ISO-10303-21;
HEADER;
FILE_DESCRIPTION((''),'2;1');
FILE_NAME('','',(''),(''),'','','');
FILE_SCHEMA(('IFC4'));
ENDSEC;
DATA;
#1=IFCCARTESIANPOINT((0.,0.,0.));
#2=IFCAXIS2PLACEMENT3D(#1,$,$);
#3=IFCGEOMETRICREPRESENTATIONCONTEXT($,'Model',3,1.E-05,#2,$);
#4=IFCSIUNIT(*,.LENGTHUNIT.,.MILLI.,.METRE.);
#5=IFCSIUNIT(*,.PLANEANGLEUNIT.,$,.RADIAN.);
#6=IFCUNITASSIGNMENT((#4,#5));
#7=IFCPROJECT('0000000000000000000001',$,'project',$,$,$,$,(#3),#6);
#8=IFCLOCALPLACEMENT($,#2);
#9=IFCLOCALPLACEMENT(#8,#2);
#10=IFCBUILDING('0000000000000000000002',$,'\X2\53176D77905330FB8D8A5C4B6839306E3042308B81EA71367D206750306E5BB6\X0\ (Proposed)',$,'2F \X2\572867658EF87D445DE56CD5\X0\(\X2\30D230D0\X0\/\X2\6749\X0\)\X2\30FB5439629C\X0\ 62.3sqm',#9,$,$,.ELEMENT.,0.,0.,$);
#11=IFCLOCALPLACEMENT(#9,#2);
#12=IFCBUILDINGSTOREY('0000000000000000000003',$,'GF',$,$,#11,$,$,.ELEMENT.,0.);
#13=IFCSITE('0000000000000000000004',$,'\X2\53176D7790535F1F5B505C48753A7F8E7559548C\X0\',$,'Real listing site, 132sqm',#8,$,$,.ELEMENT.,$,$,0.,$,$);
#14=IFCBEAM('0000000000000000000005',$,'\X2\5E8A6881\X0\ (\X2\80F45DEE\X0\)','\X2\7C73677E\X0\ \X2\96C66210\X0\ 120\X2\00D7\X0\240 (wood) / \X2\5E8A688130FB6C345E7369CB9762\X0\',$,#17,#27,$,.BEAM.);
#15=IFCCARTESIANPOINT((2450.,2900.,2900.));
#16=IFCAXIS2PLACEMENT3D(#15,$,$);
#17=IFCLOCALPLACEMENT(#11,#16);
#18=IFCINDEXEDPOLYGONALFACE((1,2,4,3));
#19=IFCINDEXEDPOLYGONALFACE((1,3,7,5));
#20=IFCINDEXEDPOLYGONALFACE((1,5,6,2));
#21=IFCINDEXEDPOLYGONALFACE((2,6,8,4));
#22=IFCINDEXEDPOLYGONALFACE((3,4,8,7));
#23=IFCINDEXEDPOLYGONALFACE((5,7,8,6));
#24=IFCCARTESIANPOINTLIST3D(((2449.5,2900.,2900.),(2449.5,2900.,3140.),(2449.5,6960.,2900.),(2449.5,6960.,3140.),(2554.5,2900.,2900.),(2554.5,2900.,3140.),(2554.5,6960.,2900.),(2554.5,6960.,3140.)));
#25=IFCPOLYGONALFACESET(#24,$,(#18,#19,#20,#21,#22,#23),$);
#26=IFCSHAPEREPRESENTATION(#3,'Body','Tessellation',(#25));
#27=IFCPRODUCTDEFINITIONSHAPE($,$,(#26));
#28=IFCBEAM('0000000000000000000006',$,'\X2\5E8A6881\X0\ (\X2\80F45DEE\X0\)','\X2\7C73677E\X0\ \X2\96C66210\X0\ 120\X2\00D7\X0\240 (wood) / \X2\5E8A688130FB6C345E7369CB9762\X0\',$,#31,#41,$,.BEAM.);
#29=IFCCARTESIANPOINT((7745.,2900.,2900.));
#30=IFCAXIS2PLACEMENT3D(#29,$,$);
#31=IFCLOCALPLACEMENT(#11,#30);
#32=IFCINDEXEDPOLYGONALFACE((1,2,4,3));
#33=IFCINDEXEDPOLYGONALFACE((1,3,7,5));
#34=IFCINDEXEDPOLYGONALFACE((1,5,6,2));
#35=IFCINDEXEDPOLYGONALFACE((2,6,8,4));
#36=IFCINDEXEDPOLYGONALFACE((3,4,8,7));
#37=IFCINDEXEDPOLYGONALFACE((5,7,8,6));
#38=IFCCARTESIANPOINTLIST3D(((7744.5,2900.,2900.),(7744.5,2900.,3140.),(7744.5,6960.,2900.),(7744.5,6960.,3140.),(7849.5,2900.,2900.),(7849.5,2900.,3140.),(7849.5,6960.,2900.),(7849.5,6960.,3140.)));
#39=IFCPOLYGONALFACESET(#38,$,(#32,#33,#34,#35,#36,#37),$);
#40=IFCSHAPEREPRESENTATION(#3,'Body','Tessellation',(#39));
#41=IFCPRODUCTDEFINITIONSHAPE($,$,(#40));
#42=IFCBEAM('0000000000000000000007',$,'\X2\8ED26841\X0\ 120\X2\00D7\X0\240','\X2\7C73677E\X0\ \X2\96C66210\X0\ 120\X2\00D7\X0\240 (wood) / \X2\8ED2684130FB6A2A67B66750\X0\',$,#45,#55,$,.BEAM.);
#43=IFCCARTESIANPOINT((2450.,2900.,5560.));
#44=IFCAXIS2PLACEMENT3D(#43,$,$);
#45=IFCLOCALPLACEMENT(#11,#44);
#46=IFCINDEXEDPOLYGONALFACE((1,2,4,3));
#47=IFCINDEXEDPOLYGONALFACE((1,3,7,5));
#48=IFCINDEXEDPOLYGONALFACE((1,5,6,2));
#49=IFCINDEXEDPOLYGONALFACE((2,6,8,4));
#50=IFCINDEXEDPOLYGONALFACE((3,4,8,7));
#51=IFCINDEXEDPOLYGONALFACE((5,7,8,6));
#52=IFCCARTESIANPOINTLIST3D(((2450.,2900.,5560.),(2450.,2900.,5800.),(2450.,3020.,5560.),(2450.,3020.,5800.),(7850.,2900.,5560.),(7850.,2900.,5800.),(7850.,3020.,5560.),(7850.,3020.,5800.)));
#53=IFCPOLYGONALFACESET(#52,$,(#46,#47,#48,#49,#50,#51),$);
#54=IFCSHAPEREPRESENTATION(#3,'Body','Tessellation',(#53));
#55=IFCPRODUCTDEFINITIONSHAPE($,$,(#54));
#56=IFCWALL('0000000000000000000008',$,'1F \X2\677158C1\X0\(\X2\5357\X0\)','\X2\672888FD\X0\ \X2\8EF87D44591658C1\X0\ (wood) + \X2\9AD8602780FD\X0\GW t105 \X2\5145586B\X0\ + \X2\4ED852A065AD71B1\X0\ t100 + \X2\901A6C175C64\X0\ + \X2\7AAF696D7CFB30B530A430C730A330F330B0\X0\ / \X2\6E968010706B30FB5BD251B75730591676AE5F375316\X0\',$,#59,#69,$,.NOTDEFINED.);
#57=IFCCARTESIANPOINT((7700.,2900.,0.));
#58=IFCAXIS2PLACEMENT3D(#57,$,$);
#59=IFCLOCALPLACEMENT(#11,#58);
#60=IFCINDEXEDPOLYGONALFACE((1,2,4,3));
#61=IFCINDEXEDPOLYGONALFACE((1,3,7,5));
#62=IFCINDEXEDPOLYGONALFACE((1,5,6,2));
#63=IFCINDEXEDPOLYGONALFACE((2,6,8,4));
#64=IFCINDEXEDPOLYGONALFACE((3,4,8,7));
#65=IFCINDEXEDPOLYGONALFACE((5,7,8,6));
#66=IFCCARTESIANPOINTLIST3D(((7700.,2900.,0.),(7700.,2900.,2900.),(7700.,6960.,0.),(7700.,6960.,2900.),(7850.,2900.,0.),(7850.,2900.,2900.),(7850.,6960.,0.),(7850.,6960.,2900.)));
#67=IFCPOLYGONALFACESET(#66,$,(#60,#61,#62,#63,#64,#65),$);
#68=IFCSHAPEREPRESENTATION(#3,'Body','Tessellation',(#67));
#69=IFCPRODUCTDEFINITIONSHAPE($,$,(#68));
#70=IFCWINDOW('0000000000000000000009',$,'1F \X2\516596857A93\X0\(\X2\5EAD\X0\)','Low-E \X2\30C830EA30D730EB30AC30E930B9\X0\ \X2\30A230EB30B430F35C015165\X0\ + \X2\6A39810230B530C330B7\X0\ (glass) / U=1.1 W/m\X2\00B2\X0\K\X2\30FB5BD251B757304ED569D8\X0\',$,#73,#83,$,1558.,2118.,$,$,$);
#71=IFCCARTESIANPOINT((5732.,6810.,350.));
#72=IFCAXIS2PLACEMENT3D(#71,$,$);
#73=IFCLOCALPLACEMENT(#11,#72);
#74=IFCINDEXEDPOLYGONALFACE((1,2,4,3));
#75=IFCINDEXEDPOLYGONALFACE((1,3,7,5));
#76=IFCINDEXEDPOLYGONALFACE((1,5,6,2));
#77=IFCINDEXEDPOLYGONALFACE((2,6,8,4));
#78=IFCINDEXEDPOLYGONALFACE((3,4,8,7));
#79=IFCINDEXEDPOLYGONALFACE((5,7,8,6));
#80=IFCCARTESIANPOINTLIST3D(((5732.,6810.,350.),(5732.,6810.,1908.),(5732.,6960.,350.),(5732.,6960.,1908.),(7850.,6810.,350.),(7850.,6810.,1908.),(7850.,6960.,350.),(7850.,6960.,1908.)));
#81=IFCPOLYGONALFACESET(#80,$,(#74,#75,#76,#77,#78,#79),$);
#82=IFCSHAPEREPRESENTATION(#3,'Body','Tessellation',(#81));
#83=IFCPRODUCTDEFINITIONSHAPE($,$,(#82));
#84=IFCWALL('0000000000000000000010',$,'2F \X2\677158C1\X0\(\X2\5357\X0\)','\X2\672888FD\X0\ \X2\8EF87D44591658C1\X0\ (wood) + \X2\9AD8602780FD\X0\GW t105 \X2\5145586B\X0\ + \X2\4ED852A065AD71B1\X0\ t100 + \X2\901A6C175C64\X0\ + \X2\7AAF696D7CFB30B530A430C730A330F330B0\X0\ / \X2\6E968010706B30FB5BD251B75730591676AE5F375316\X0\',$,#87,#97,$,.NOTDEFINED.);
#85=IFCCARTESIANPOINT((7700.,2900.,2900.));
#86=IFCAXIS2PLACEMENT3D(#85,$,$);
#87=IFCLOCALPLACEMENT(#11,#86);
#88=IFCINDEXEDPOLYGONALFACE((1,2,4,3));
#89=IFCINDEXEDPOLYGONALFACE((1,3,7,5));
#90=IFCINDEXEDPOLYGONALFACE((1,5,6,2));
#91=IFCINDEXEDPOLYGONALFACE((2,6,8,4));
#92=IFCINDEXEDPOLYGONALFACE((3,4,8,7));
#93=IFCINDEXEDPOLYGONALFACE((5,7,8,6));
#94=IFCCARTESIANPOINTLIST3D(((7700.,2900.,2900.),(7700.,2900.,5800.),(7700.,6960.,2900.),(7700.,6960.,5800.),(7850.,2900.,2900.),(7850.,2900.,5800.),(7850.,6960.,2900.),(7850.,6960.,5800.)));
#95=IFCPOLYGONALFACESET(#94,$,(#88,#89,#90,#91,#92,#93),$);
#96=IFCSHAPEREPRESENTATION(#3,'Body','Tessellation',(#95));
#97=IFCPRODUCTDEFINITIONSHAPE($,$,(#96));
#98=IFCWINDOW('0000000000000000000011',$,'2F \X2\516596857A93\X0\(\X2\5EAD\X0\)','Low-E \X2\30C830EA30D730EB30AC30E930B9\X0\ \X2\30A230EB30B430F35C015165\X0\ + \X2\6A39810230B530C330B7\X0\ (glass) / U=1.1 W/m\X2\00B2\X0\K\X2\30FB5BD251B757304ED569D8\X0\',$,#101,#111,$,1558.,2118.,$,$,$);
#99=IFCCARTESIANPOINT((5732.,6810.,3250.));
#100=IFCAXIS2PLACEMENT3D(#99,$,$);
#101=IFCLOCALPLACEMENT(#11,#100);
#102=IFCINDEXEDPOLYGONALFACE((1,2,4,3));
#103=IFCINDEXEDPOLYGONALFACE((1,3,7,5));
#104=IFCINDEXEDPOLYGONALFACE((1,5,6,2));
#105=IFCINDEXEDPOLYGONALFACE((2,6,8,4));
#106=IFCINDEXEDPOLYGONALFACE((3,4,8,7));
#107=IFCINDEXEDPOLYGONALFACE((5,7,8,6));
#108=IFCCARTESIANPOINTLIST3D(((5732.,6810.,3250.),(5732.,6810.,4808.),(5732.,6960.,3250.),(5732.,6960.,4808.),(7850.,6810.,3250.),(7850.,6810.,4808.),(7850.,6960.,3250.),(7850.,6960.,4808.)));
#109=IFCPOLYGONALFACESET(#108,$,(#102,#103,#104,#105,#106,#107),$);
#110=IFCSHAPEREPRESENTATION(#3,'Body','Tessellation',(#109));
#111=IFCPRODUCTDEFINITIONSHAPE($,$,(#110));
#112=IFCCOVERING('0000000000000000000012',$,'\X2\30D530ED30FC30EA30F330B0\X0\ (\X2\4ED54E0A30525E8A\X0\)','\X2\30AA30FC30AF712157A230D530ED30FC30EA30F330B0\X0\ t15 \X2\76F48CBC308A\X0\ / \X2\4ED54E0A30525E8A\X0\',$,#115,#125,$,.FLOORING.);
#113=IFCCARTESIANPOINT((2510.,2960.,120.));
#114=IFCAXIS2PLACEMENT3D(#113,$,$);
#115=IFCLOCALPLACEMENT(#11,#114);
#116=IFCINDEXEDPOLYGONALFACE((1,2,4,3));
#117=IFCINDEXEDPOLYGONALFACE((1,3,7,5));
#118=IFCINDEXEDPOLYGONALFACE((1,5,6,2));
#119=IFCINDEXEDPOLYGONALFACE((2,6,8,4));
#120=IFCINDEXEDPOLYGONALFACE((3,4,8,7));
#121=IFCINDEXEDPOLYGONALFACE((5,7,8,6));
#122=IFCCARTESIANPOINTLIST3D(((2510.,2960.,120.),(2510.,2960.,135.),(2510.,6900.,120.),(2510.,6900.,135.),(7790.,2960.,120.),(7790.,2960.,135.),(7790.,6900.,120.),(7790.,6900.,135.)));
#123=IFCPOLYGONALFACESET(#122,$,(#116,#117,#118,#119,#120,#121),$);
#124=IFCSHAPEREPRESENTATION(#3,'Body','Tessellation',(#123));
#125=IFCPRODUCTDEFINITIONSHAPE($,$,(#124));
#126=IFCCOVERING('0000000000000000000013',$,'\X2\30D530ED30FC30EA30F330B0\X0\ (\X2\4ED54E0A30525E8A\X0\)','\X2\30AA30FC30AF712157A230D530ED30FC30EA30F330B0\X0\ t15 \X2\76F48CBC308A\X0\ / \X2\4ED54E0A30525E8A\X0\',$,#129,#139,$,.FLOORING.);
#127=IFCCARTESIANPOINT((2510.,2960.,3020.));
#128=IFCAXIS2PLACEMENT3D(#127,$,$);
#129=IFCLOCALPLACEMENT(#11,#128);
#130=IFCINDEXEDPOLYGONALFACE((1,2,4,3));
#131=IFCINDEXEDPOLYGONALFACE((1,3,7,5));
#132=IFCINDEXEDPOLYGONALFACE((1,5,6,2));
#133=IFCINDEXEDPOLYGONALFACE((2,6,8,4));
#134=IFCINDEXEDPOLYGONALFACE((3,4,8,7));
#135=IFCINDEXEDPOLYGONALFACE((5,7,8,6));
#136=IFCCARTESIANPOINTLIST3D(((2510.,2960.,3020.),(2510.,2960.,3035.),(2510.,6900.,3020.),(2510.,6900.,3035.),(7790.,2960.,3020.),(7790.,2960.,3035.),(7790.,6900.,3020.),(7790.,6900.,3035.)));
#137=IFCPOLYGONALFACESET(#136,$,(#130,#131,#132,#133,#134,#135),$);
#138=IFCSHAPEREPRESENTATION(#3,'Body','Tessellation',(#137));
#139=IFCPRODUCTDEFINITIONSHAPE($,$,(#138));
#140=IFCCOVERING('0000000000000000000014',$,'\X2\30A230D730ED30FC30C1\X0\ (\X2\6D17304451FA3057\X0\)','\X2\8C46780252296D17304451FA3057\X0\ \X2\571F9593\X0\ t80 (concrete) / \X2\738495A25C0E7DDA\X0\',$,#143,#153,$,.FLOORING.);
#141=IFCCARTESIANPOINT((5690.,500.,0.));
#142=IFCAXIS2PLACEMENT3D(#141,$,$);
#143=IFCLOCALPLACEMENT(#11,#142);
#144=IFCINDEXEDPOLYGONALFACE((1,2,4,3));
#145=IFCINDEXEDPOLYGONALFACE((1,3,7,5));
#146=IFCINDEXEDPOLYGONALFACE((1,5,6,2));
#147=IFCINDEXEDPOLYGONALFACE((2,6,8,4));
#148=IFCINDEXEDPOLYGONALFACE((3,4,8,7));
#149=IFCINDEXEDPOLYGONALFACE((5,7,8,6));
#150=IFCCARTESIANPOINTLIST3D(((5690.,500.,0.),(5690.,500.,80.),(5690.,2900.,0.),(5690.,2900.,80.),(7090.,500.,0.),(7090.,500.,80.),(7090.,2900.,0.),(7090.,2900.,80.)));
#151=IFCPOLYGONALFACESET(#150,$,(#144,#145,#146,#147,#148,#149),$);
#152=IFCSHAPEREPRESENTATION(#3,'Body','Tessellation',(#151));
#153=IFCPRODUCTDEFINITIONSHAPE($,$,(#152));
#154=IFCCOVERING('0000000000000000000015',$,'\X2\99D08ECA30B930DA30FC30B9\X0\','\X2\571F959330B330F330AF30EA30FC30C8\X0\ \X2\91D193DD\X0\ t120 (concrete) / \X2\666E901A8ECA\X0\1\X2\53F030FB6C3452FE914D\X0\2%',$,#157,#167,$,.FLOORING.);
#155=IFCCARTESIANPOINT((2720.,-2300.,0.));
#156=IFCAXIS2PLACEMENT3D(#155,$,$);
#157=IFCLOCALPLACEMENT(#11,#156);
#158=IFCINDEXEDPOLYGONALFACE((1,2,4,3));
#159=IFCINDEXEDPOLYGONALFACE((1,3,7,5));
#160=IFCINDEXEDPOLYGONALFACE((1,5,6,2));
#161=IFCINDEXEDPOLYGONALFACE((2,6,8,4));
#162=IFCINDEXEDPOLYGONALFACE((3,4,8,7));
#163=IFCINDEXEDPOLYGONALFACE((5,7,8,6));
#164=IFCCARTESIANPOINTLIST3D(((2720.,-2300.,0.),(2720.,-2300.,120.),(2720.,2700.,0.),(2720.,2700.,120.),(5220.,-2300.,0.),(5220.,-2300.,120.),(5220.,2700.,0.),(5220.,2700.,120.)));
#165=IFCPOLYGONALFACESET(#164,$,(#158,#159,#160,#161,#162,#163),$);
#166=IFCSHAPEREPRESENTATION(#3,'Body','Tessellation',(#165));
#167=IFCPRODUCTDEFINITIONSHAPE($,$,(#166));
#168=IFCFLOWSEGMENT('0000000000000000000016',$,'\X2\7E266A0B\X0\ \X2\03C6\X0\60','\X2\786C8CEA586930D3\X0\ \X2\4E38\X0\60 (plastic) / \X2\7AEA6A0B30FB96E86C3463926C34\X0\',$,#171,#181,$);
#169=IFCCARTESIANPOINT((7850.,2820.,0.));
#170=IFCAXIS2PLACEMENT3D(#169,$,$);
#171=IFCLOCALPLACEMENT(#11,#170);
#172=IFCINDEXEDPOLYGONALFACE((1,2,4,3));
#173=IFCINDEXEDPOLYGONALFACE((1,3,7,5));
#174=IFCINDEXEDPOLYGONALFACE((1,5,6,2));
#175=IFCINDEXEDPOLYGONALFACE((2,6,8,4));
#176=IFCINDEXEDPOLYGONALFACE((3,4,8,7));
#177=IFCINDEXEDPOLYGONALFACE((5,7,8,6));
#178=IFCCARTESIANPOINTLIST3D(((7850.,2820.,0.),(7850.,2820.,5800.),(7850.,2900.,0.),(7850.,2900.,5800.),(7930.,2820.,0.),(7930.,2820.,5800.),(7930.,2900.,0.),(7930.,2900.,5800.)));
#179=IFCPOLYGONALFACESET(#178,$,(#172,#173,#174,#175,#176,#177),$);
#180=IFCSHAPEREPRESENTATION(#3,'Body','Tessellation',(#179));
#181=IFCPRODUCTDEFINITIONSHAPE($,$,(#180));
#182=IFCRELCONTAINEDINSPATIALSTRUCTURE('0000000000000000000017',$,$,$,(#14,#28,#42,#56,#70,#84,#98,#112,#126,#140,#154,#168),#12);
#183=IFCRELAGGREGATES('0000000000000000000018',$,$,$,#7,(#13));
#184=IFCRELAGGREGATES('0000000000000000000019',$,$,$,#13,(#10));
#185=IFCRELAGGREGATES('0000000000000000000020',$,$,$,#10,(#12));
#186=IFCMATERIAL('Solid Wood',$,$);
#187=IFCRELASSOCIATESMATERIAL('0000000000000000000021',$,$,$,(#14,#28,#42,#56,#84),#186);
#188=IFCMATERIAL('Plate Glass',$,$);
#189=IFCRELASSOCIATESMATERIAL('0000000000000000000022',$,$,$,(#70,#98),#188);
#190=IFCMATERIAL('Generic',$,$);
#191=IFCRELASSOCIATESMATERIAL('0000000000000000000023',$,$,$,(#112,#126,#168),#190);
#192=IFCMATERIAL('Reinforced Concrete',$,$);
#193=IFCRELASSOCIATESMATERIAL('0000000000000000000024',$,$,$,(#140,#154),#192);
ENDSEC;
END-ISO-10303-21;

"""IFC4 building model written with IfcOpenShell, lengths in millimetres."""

from ifc_helpers import new_model, si_unit, frame, frame_2d, origin, place, context, project, spatial, rectangle, extrude, material, element, fill, save


model = new_model("IFC4")

# Units and contexts
model_context = context("Model", 3, precision=1e-05, world=origin())
ifc_project = project(units=[si_unit("LENGTHUNIT", "METRE", prefix="MILLI"), si_unit("PLANEANGLEUNIT", "RADIAN")], contexts=[model_context])

# Site, building, storey
site_placement = place(None, origin())
site = spatial("IfcSite", under=ifc_project, at=site_placement, Name="北海道弟子屈町美留和", ObjectType="Real listing site, 132sqm", CompositionType="ELEMENT", RefElevation=0.0)
building_placement = place(site_placement, origin())
building = spatial("IfcBuilding", under=site, at=building_placement, Name="北海道・越屋根のある自然素材の家 (Proposed)", ObjectType="2F 在来軸組工法(ヒバ/杉)・吹抜 62.3sqm", CompositionType="ELEMENT", ElevationOfRefHeight=0.0, ElevationOfTerrain=0.0)
storey_placement = place(building_placement, origin())
storey = spatial("IfcBuildingStorey", under=building, at=storey_placement, Name="GF", CompositionType="ELEMENT", Elevation=0.0)

# Shared definitions
ifc_material_1 = material(Name="Solid Wood")

# Beams
beam_1_placement = place(storey_placement, frame((2450.0, 2900.0, 2900.0)))
element("IfcBeam", 1, at=beam_1_placement, inside=storey, material=ifc_material_1, Name="床梁 (胴差)", Description="米松 集成 120×240 (wood) / 床梁・水平構面", PredefinedType="BEAM", context=model_context, shape_type="SweptSolid", body=[
    extrude(rectangle(XDim=105.0, YDim=4060.0, at=frame_2d((52.0, 2030.0))), frame((2450.0, 2900.0, 2900.0)), (0.0, 0.0, 1.0), 240.0),
])
beam_2_placement = place(storey_placement, frame((7745.0, 2900.0, 2900.0)))
element("IfcBeam", 2, at=beam_2_placement, inside=storey, material=ifc_material_1, Name="床梁 (胴差)", Description="米松 集成 120×240 (wood) / 床梁・水平構面", PredefinedType="BEAM", context=model_context, shape_type="SweptSolid", body=[
    extrude(rectangle(XDim=105.0, YDim=4060.0, at=frame_2d((52.0, 2030.0))), frame((7745.0, 2900.0, 2900.0)), (0.0, 0.0, 1.0), 240.0),
])
beam_3_placement = place(storey_placement, frame((2450.0, 2900.0, 5560.0)))
element("IfcBeam", 3, at=beam_3_placement, inside=storey, material=ifc_material_1, Name="軒桁 120×240", Description="米松 集成 120×240 (wood) / 軒桁・横架材", PredefinedType="BEAM", context=model_context, shape_type="SweptSolid", body=[
    extrude(rectangle(XDim=5400.0, YDim=120.0, at=frame_2d((2700.0, 60.0))), frame((2450.0, 2900.0, 5560.0)), (0.0, 0.0, 1.0), 240.0),
])

# Wall, opening, window
wall_1_placement = place(storey_placement, frame((7700.0, 2900.0, 0.0)))
wall_1 = element("IfcWall", 4, at=wall_1_placement, inside=storey, material=ifc_material_1, Name="1F 東壁(南)", Description="木製 軸組外壁 (wood) + 高性能GW t105 充填 + 付加断熱 t100 + 通気層 + 窯業系サイディング / 準耐火・寒冷地外皮強化", PredefinedType="NOTDEFINED", context=model_context, shape_type="SweptSolid", body=[
    extrude(rectangle(XDim=150.0, YDim=4060.0, at=frame_2d((75.0, 2030.0))), frame((7700.0, 2900.0, 0.0)), (0.0, 0.0, 1.0), 2900.0),
])
opening_1_placement = place(storey_placement, frame((5732.0, 6810.0, 350.0)))
opening_1 = element("IfcOpeningElement", 5, at=opening_1_placement, cuts=wall_1, PredefinedType="NOTDEFINED", context=model_context, shape_type="SweptSolid", body=[
    extrude(rectangle(XDim=2118.0, YDim=150.0, at=frame_2d((1059.0, 75.0))), frame((5732.0, 6810.0, 350.0)), (0.0, 0.0, 1.0), 1558.0),
])
ifc_material_2 = material(Name="Plate Glass")
window_1_placement = place(storey_placement, frame((5732.0, 6810.0, 350.0)))
window_1 = element("IfcWindow", 6, at=window_1_placement, inside=storey, material=ifc_material_2, Name="1F 入隅窓(庭)", Description="Low-E トリプルガラス アルゴン封入 + 樹脂サッシ (glass) / U=1.1 W/m²K・寒冷地仕様", OverallHeight=1558.0, OverallWidth=2118.0, context=model_context, shape_type="SweptSolid", body=[
    extrude(rectangle(XDim=2118.0, YDim=150.0, at=frame_2d((1059.0, 75.0))), frame((5732.0, 6810.0, 350.0)), (0.0, 0.0, 1.0), 1558.0),
])
fill(opening_1, window_1)

# Wall, opening, window
wall_2_placement = place(storey_placement, frame((7700.0, 2900.0, 2900.0)))
wall_2 = element("IfcWall", 7, at=wall_2_placement, inside=storey, material=ifc_material_1, Name="2F 東壁(南)", Description="木製 軸組外壁 (wood) + 高性能GW t105 充填 + 付加断熱 t100 + 通気層 + 窯業系サイディング / 準耐火・寒冷地外皮強化", PredefinedType="NOTDEFINED", context=model_context, shape_type="SweptSolid", body=[
    extrude(rectangle(XDim=150.0, YDim=4060.0, at=frame_2d((75.0, 2030.0))), frame((7700.0, 2900.0, 2900.0)), (0.0, 0.0, 1.0), 2900.0),
])
opening_2_placement = place(storey_placement, frame((5732.0, 6810.0, 3250.0)))
opening_2 = element("IfcOpeningElement", 8, at=opening_2_placement, cuts=wall_2, PredefinedType="NOTDEFINED", context=model_context, shape_type="SweptSolid", body=[
    extrude(rectangle(XDim=2118.0, YDim=150.0, at=frame_2d((1059.0, 75.0))), frame((5732.0, 6810.0, 3250.0)), (0.0, 0.0, 1.0), 1558.0),
])
window_2_placement = place(storey_placement, frame((5732.0, 6810.0, 3250.0)))
window_2 = element("IfcWindow", 9, at=window_2_placement, inside=storey, material=ifc_material_2, Name="2F 入隅窓(庭)", Description="Low-E トリプルガラス アルゴン封入 + 樹脂サッシ (glass) / U=1.1 W/m²K・寒冷地仕様", OverallHeight=1558.0, OverallWidth=2118.0, context=model_context, shape_type="SweptSolid", body=[
    extrude(rectangle(XDim=2118.0, YDim=150.0, at=frame_2d((1059.0, 75.0))), frame((5732.0, 6810.0, 3250.0)), (0.0, 0.0, 1.0), 1558.0),
])
fill(opening_2, window_2)

# Coverings
ifc_material_3 = material(Name="Generic")
covering_1_placement = place(storey_placement, frame((2510.0, 2960.0, 120.0)))
element("IfcCovering", 10, at=covering_1_placement, inside=storey, material=ifc_material_3, Name="フローリング (仕上げ床)", Description="オーク無垢フローリング t15 直貼り / 仕上げ床", PredefinedType="FLOORING", context=model_context, shape_type="SweptSolid", body=[
    extrude(rectangle(XDim=5280.0, YDim=3940.0, at=frame_2d((2640.0, 1970.0))), frame((2510.0, 2960.0, 120.0)), (0.0, 0.0, 1.0), 15.0),
])
covering_2_placement = place(storey_placement, frame((2510.0, 2960.0, 3020.0)))
element("IfcCovering", 11, at=covering_2_placement, inside=storey, material=ifc_material_3, Name="フローリング (仕上げ床)", Description="オーク無垢フローリング t15 直貼り / 仕上げ床", PredefinedType="FLOORING", context=model_context, shape_type="SweptSolid", body=[
    extrude(rectangle(XDim=5280.0, YDim=3940.0, at=frame_2d((2640.0, 1970.0))), frame((2510.0, 2960.0, 3020.0)), (0.0, 0.0, 1.0), 15.0),
])
ifc_material_4 = material(Name="Reinforced Concrete")
covering_3_placement = place(storey_placement, frame((5690.0, 500.0, 0.0)))
element("IfcCovering", 12, at=covering_3_placement, inside=storey, material=ifc_material_4, Name="アプローチ (洗い出し)", Description="豆砂利洗い出し 土間 t80 (concrete) / 玄関導線", PredefinedType="FLOORING", context=model_context, shape_type="SweptSolid", body=[
    extrude(rectangle(XDim=1400.0, YDim=2400.0, at=frame_2d((700.0, 1200.0))), frame((5690.0, 500.0, 0.0)), (0.0, 0.0, 1.0), 80.0),
])
covering_4_placement = place(storey_placement, frame((2720.0, -2300.0, 0.0)))
element("IfcCovering", 13, at=covering_4_placement, inside=storey, material=ifc_material_4, Name="駐車スペース", Description="土間コンクリート 金鏝 t120 (concrete) / 普通車1台・水勾配2%", PredefinedType="FLOORING", context=model_context, shape_type="SweptSolid", body=[
    extrude(rectangle(XDim=2500.0, YDim=5000.0, at=frame_2d((1250.0, 2500.0))), frame((2720.0, -2300.0, 0.0)), (0.0, 0.0, 1.0), 120.0),
])

# Flow segment
flow_segment_placement = place(storey_placement, frame((7850.0, 2820.0, 0.0)))
element("IfcFlowSegment", 14, at=flow_segment_placement, inside=storey, material=ifc_material_3, Name="縦樋 φ60", Description="硬質塩ビ 丸60 (plastic) / 竪樋・雨水排水", context=model_context, shape_type="SweptSolid", body=[
    extrude(rectangle(XDim=80.0, YDim=80.0, at=frame_2d((40.0, 40.0))), frame((7850.0, 2820.0, 0.0)), (0.0, 0.0, 1.0), 5800.0),
])

save(model, "model.ifc")
